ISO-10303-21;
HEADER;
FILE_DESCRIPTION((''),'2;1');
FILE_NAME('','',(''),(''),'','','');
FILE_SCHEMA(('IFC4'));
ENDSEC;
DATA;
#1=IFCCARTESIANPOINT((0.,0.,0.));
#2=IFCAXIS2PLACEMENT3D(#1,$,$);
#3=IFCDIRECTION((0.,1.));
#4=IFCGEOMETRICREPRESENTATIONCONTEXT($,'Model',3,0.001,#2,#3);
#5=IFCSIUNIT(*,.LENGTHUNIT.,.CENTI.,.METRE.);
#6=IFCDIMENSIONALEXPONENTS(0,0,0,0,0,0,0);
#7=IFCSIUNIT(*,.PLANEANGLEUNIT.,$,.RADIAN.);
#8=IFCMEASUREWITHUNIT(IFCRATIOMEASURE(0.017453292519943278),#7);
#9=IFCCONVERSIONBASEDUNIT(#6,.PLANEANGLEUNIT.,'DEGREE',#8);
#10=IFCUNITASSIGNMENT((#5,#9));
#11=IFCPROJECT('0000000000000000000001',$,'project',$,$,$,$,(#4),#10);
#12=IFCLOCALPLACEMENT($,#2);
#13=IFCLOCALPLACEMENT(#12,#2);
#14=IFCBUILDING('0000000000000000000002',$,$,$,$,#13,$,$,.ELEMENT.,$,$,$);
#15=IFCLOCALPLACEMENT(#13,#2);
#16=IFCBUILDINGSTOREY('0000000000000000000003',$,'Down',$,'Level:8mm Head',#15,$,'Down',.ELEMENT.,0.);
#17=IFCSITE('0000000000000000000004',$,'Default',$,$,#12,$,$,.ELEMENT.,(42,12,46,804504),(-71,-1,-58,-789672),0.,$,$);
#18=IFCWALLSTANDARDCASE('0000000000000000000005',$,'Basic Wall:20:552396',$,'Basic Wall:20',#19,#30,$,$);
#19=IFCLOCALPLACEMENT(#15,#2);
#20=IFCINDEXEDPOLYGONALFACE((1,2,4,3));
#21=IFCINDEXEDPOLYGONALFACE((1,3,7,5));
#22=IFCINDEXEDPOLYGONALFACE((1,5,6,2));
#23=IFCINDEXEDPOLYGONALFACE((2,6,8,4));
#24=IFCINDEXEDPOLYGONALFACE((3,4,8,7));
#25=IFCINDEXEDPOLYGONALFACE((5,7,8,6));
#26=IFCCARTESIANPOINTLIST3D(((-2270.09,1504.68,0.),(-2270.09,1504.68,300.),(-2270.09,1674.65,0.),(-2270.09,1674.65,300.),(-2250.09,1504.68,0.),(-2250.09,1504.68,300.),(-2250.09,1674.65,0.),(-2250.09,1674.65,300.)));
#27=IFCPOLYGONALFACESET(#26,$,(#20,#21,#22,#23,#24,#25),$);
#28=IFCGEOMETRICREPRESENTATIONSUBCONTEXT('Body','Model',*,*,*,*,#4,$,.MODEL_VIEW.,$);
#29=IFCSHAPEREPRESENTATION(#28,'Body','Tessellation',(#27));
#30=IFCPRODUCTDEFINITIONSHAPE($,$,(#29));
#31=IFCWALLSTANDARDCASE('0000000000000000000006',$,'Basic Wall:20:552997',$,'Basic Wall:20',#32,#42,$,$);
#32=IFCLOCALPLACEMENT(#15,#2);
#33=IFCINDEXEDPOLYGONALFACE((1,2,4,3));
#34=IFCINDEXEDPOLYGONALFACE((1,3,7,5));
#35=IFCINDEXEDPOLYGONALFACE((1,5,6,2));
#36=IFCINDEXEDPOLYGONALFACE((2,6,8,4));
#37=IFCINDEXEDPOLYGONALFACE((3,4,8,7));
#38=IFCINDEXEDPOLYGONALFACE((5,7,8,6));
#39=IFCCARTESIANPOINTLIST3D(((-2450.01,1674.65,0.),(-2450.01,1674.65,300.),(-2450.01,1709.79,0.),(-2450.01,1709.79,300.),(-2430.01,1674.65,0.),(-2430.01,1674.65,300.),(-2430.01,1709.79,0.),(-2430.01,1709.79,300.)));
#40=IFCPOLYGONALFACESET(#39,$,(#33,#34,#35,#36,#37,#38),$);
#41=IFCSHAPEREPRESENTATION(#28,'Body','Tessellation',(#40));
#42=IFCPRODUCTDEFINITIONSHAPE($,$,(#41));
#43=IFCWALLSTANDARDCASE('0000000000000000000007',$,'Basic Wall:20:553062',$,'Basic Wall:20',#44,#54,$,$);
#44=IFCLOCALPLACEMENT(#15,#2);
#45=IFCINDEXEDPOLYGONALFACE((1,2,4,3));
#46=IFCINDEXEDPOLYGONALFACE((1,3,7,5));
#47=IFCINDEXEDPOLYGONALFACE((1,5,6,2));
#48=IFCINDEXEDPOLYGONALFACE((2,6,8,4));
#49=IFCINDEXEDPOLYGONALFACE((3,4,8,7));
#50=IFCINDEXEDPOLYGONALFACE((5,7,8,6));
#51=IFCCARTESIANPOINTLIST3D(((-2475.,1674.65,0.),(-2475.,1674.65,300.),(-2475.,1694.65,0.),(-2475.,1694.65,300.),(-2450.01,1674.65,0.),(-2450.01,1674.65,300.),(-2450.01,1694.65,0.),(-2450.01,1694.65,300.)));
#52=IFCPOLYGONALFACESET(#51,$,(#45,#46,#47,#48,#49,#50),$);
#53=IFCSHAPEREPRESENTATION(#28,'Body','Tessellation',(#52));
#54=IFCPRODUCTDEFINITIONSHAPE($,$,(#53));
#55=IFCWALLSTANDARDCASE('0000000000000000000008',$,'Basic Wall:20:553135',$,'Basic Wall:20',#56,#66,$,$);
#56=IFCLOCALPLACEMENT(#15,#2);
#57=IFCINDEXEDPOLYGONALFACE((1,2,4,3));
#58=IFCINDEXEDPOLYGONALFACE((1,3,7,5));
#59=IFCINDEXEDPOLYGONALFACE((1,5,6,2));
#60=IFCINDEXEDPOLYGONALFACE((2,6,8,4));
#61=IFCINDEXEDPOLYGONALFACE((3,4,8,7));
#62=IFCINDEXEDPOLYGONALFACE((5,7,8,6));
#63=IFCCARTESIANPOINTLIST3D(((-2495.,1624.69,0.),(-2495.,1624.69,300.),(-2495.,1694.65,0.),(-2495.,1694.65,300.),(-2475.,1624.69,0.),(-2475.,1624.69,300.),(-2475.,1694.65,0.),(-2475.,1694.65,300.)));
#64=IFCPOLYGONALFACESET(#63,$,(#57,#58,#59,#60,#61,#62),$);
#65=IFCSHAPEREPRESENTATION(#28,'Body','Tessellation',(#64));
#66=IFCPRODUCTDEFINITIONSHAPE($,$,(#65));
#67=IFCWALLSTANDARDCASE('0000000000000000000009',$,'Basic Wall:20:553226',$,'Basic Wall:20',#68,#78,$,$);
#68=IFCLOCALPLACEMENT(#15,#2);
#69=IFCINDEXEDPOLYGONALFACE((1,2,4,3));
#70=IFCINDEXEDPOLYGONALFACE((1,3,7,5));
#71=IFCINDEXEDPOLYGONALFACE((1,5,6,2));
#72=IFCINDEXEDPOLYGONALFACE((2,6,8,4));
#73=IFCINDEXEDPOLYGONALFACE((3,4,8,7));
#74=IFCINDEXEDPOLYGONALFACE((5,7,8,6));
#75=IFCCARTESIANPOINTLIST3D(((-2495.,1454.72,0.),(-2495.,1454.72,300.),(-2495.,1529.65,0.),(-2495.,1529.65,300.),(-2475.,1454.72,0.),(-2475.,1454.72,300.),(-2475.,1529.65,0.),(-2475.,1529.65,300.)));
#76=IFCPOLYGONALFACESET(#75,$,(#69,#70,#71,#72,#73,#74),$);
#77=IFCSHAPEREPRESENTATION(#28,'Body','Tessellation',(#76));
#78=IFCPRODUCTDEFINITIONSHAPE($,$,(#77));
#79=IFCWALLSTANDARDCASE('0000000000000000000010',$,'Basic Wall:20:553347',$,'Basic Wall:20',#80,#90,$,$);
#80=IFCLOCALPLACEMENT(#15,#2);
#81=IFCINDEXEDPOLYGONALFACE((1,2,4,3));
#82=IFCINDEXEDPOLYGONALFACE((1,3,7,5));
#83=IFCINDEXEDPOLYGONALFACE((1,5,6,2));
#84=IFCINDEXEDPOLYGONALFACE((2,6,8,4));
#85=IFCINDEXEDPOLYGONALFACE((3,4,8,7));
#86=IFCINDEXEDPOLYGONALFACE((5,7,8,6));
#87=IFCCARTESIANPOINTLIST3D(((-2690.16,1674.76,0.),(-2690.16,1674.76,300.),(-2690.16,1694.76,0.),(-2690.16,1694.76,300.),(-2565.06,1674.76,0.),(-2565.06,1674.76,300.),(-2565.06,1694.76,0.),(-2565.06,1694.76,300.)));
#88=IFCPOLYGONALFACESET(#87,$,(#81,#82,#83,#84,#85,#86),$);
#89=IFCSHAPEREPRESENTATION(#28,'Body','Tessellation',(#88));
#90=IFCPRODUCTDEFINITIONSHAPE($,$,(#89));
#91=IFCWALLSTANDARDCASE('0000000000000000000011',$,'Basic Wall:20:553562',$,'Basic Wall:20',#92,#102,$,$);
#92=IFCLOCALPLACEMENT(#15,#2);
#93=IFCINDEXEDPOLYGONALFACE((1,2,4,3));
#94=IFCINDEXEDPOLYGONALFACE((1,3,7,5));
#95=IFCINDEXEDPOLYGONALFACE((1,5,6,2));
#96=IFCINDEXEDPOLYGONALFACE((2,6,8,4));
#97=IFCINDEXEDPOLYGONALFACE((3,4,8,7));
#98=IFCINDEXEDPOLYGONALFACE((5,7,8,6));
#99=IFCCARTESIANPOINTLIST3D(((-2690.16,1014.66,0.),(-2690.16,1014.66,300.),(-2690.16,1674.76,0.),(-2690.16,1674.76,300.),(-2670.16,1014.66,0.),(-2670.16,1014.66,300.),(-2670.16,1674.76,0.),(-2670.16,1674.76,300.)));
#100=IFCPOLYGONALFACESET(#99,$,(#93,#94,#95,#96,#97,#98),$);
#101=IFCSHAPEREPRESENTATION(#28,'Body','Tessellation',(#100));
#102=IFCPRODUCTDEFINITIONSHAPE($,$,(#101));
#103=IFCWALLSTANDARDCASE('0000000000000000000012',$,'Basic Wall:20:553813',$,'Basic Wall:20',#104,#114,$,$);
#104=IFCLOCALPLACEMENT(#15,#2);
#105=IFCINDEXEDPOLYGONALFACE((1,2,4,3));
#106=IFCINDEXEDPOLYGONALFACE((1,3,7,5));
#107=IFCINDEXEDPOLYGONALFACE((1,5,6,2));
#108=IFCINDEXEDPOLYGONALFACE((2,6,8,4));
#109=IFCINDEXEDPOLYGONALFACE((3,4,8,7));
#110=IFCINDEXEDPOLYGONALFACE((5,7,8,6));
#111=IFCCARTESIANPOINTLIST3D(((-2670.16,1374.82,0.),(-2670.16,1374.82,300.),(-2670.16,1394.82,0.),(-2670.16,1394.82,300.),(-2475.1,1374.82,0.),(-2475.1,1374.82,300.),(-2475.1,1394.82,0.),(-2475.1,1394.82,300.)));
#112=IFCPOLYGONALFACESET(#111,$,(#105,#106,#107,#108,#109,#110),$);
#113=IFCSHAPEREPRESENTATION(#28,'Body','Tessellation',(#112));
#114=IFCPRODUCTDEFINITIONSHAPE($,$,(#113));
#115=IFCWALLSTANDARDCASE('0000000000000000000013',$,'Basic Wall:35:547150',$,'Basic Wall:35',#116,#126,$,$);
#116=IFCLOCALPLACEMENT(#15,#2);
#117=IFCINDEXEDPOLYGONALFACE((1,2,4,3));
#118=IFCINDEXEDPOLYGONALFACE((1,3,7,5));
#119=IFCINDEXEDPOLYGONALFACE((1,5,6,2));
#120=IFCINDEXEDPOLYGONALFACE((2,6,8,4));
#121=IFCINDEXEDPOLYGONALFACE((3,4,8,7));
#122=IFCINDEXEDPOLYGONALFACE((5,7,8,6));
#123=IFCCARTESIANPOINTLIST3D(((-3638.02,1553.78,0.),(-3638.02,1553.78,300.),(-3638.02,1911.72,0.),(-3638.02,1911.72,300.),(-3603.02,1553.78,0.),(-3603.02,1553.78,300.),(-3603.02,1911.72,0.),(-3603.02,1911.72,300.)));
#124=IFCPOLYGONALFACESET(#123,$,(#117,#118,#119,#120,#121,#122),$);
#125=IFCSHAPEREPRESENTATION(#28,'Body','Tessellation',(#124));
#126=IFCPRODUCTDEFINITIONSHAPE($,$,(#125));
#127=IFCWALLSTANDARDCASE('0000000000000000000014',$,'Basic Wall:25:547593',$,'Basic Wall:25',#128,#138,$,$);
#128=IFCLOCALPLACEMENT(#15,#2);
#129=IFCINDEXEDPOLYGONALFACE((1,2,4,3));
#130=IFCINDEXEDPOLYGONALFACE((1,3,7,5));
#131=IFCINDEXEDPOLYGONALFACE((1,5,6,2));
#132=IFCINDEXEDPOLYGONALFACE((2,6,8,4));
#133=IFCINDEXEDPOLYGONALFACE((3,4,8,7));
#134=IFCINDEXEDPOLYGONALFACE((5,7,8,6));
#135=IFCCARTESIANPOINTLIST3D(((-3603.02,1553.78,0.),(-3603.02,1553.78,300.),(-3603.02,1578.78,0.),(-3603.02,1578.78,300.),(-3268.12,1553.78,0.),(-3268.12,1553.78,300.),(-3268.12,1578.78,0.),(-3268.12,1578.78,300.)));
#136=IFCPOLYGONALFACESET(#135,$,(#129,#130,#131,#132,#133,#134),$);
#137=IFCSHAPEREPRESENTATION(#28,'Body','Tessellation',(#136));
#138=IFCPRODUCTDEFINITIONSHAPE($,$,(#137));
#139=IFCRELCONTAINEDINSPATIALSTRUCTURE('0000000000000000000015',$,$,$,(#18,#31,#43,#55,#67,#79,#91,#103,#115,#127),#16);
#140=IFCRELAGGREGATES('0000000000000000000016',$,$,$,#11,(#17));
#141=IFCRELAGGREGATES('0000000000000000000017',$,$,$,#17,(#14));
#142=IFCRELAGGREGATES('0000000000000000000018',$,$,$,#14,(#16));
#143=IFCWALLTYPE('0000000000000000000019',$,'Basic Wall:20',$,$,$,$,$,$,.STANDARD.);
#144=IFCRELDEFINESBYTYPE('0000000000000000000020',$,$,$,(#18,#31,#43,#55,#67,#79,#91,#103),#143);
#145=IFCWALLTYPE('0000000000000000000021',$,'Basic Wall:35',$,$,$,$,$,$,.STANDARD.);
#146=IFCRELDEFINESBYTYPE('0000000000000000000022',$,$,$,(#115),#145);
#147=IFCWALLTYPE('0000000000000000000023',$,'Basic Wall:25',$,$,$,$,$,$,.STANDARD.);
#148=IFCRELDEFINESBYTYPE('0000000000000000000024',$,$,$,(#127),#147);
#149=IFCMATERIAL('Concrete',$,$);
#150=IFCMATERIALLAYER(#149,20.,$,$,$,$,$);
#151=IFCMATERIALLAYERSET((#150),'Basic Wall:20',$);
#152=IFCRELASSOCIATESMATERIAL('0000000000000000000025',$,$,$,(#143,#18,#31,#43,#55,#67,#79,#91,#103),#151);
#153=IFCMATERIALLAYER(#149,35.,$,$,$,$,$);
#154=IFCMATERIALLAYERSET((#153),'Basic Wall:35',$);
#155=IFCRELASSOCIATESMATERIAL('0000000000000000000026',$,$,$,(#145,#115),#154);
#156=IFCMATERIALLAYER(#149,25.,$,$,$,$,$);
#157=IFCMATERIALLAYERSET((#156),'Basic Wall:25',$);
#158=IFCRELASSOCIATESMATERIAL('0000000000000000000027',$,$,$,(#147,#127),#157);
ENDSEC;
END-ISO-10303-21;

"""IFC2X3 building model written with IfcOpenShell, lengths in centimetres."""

from ifc_helpers import new_model, entity, si_unit, converted_unit, direction, frame, frame_2d, origin, place, context, subcontext, project, spatial, rectangle, extrude, material, layer, layer_set, layer_usage, type_object, element, save


model = new_model("IFC2X3")

# Units and contexts
model_context = context("Model", 3, precision=0.001, world=origin(), true_north=direction((0.0, 1.0)))
body_context = subcontext(model_context, "Body", "Model", "MODEL_VIEW")
ifc_project = project(units=[si_unit("LENGTHUNIT", "METRE", prefix="CENTI"), converted_unit("PLANEANGLEUNIT", "DEGREE", entity("IfcRatioMeasure", 0.017453292519943278), si_unit("PLANEANGLEUNIT", "RADIAN"), dimensions=[0, 0, 0, 0, 0, 0, 0])], contexts=[model_context])

# Site, building, storey
site_placement = place(None, origin())
site = spatial("IfcSite", under=ifc_project, at=site_placement, Name="Default", CompositionType="ELEMENT", RefLatitude=(42, 12, 46, 804504), RefLongitude=(-71, -1, -58, -789672), RefElevation=0.0)
building_placement = place(site_placement, origin())
building = spatial("IfcBuilding", under=site, at=building_placement, CompositionType="ELEMENT")
storey_placement = place(building_placement, origin())
storey = spatial("IfcBuildingStorey", under=building, at=storey_placement, Name="Down", ObjectType="Level:8mm Head", LongName="Down", CompositionType="ELEMENT", Elevation=0.0)

# Walls
ifc_material = material(Name="Concrete")
ifc_layer_1 = layer(ifc_material, 20.0)
ifc_layer_set_1 = layer_set([ifc_layer_1], Name="Basic Wall:20")
wall_type_1 = type_object("IfcWallType", Name="Basic Wall:20", PredefinedType="STANDARD", material=ifc_layer_set_1)
ifc_layer_usage_1 = layer_usage(ifc_layer_set_1, "AXIS2", "POSITIVE", -10.0)
wall_1_placement = place(storey_placement, frame((-2260.09, 1504.68, 0.0), z_axis=(0.0, 0.0, 1.0), x_axis=(0.0, 1.0, 0.0)))
element("IfcWallStandardCase", 1, at=wall_1_placement, inside=storey, type_object=wall_type_1, material=ifc_layer_usage_1, Name="Basic Wall:20:552396", ObjectType="Basic Wall:20", context=body_context, shape_type="SweptSolid", body=[
    extrude(rectangle(XDim=169.97, YDim=20.0, at=frame_2d((84.99, 0.0), x_axis=(-1.0, 0.0))), origin(), (0.0, 0.0, 1.0), 300.0),
])
ifc_layer_usage_2 = layer_usage(ifc_layer_set_1, "AXIS2", "NEGATIVE", 10.0)
wall_2_placement = place(storey_placement, frame((-2440.01, 1709.79, 0.0), z_axis=(0.0, 0.0, 1.0), x_axis=(0.0, -1.0, 0.0)))
element("IfcWallStandardCase", 2, at=wall_2_placement, inside=storey, type_object=wall_type_1, material=ifc_layer_usage_2, Name="Basic Wall:20:552997", ObjectType="Basic Wall:20", context=body_context, shape_type="SweptSolid", body=[
    extrude(rectangle(XDim=35.14, YDim=20.0, at=frame_2d((17.57, 0.0), x_axis=(-1.0, 0.0))), origin(), (0.0, 0.0, 1.0), 300.0),
])
ifc_layer_usage_3 = layer_usage(ifc_layer_set_1, "AXIS2", "NEGATIVE", 10.0)
wall_3_placement = place(storey_placement, frame((-2450.01, 1684.65, 0.0), z_axis=(0.0, 0.0, 1.0), x_axis=(-1.0, 0.0, 0.0)))
element("IfcWallStandardCase", 3, at=wall_3_placement, inside=storey, type_object=wall_type_1, material=ifc_layer_usage_3, Name="Basic Wall:20:553062", ObjectType="Basic Wall:20", context=body_context, shape_type="SweptSolid", body=[
    extrude(rectangle(XDim=24.98, YDim=20.0, at=frame_2d((12.49, 0.0), x_axis=(-1.0, 0.0))), origin(), (0.0, 0.0, 1.0), 300.0),
])
ifc_layer_usage_4 = layer_usage(ifc_layer_set_1, "AXIS2", "POSITIVE", -10.0)
wall_4_placement = place(storey_placement, frame((-2485.0, 1694.65, 0.0), z_axis=(0.0, 0.0, 1.0), x_axis=(0.0, -1.0, 0.0)))
element("IfcWallStandardCase", 4, at=wall_4_placement, inside=storey, type_object=wall_type_1, material=ifc_layer_usage_4, Name="Basic Wall:20:553135", ObjectType="Basic Wall:20", context=body_context, shape_type="SweptSolid", body=[
    extrude(rectangle(XDim=69.95, YDim=20.0, at=frame_2d((34.98, 0.0), x_axis=(-1.0, 0.0))), origin(), (0.0, 0.0, 1.0), 300.0),
])
ifc_layer_usage_5 = layer_usage(ifc_layer_set_1, "AXIS2", "POSITIVE", -10.0)
wall_5_placement = place(storey_placement, frame((-2485.0, 1529.65, 0.0), z_axis=(0.0, 0.0, 1.0), x_axis=(0.0, -1.0, 0.0)))
element("IfcWallStandardCase", 5, at=wall_5_placement, inside=storey, type_object=wall_type_1, material=ifc_layer_usage_5, Name="Basic Wall:20:553226", ObjectType="Basic Wall:20", context=body_context, shape_type="SweptSolid", body=[
    extrude(rectangle(XDim=74.93, YDim=20.0, at=frame_2d((37.47, 0.0), x_axis=(-1.0, 0.0))), origin(), (0.0, 0.0, 1.0), 300.0),
])
ifc_layer_usage_6 = layer_usage(ifc_layer_set_1, "AXIS2", "POSITIVE", -10.0)
wall_6_placement = place(storey_placement, frame((-2565.06, 1684.76, 0.0), z_axis=(0.0, 0.0, 1.0), x_axis=(-1.0, 0.0, 0.0)))
element("IfcWallStandardCase", 6, at=wall_6_placement, inside=storey, type_object=wall_type_1, material=ifc_layer_usage_6, Name="Basic Wall:20:553347", ObjectType="Basic Wall:20", context=body_context, shape_type="SweptSolid", body=[
    extrude(rectangle(XDim=125.1, YDim=20.0, at=frame_2d((62.55, 0.0), x_axis=(-1.0, 0.0))), origin(), (0.0, 0.0, 1.0), 300.0),
])
ifc_layer_usage_7 = layer_usage(ifc_layer_set_1, "AXIS2", "POSITIVE", -10.0)
wall_7_placement = place(storey_placement, frame((-2680.16, 1674.76, 0.0), z_axis=(0.0, 0.0, 1.0), x_axis=(0.0, -1.0, 0.0)))
element("IfcWallStandardCase", 7, at=wall_7_placement, inside=storey, type_object=wall_type_1, material=ifc_layer_usage_7, Name="Basic Wall:20:553562", ObjectType="Basic Wall:20", context=body_context, shape_type="SweptSolid", body=[
    extrude(rectangle(XDim=660.1, YDim=20.0, at=frame_2d((330.05, 0.0), x_axis=(-1.0, 0.0))), origin(), (0.0, 0.0, 1.0), 300.0),
])
ifc_layer_usage_8 = layer_usage(ifc_layer_set_1, "AXIS2", "POSITIVE", -10.0)
wall_8_placement = place(storey_placement, frame((-2475.1, 1384.82, 0.0), z_axis=(0.0, 0.0, 1.0), x_axis=(-1.0, 0.0, 0.0)))
element("IfcWallStandardCase", 8, at=wall_8_placement, inside=storey, type_object=wall_type_1, material=ifc_layer_usage_8, Name="Basic Wall:20:553813", ObjectType="Basic Wall:20", context=body_context, shape_type="SweptSolid", body=[
    extrude(rectangle(XDim=195.06, YDim=20.0, at=frame_2d((97.53, 0.0), x_axis=(-1.0, 0.0))), origin(), (0.0, 0.0, 1.0), 300.0),
])
ifc_layer_2 = layer(ifc_material, 35.0)
ifc_layer_set_2 = layer_set([ifc_layer_2], Name="Basic Wall:35")
ifc_layer_usage_9 = layer_usage(ifc_layer_set_2, "AXIS2", "POSITIVE", -17.5)
wall_type_2 = type_object("IfcWallType", Name="Basic Wall:35", PredefinedType="STANDARD", material=ifc_layer_set_2)
wall_9_placement = place(storey_placement, frame((-3620.52, 1911.72, 0.0), z_axis=(0.0, 0.0, 1.0), x_axis=(0.0, -1.0, 0.0)))
element("IfcWallStandardCase", 9, at=wall_9_placement, inside=storey, type_object=wall_type_2, material=ifc_layer_usage_9, Name="Basic Wall:35:547150", ObjectType="Basic Wall:35", context=body_context, shape_type="SweptSolid", body=[
    extrude(rectangle(XDim=357.94, YDim=35.0, at=frame_2d((178.97, 0.0), x_axis=(-1.0, 0.0))), origin(), (0.0, 0.0, 1.0), 300.0),
])
ifc_layer_3 = layer(ifc_material, 25.0)
ifc_layer_set_3 = layer_set([ifc_layer_3], Name="Basic Wall:25")
ifc_layer_usage_10 = layer_usage(ifc_layer_set_3, "AXIS2", "POSITIVE", -12.5)
wall_type_3 = type_object("IfcWallType", Name="Basic Wall:25", PredefinedType="STANDARD", material=ifc_layer_set_3)
wall_10_placement = place(storey_placement, frame((-3603.02, 1566.28, 0.0)))
element("IfcWallStandardCase", 10, at=wall_10_placement, inside=storey, type_object=wall_type_3, material=ifc_layer_usage_10, Name="Basic Wall:25:547593", ObjectType="Basic Wall:25", context=body_context, shape_type="SweptSolid", body=[
    extrude(rectangle(XDim=334.9, YDim=25.0, at=frame_2d((167.45, 0.0), x_axis=(-1.0, 0.0))), origin(), (0.0, 0.0, 1.0), 300.0),
])

save(model, "model.ifc")
